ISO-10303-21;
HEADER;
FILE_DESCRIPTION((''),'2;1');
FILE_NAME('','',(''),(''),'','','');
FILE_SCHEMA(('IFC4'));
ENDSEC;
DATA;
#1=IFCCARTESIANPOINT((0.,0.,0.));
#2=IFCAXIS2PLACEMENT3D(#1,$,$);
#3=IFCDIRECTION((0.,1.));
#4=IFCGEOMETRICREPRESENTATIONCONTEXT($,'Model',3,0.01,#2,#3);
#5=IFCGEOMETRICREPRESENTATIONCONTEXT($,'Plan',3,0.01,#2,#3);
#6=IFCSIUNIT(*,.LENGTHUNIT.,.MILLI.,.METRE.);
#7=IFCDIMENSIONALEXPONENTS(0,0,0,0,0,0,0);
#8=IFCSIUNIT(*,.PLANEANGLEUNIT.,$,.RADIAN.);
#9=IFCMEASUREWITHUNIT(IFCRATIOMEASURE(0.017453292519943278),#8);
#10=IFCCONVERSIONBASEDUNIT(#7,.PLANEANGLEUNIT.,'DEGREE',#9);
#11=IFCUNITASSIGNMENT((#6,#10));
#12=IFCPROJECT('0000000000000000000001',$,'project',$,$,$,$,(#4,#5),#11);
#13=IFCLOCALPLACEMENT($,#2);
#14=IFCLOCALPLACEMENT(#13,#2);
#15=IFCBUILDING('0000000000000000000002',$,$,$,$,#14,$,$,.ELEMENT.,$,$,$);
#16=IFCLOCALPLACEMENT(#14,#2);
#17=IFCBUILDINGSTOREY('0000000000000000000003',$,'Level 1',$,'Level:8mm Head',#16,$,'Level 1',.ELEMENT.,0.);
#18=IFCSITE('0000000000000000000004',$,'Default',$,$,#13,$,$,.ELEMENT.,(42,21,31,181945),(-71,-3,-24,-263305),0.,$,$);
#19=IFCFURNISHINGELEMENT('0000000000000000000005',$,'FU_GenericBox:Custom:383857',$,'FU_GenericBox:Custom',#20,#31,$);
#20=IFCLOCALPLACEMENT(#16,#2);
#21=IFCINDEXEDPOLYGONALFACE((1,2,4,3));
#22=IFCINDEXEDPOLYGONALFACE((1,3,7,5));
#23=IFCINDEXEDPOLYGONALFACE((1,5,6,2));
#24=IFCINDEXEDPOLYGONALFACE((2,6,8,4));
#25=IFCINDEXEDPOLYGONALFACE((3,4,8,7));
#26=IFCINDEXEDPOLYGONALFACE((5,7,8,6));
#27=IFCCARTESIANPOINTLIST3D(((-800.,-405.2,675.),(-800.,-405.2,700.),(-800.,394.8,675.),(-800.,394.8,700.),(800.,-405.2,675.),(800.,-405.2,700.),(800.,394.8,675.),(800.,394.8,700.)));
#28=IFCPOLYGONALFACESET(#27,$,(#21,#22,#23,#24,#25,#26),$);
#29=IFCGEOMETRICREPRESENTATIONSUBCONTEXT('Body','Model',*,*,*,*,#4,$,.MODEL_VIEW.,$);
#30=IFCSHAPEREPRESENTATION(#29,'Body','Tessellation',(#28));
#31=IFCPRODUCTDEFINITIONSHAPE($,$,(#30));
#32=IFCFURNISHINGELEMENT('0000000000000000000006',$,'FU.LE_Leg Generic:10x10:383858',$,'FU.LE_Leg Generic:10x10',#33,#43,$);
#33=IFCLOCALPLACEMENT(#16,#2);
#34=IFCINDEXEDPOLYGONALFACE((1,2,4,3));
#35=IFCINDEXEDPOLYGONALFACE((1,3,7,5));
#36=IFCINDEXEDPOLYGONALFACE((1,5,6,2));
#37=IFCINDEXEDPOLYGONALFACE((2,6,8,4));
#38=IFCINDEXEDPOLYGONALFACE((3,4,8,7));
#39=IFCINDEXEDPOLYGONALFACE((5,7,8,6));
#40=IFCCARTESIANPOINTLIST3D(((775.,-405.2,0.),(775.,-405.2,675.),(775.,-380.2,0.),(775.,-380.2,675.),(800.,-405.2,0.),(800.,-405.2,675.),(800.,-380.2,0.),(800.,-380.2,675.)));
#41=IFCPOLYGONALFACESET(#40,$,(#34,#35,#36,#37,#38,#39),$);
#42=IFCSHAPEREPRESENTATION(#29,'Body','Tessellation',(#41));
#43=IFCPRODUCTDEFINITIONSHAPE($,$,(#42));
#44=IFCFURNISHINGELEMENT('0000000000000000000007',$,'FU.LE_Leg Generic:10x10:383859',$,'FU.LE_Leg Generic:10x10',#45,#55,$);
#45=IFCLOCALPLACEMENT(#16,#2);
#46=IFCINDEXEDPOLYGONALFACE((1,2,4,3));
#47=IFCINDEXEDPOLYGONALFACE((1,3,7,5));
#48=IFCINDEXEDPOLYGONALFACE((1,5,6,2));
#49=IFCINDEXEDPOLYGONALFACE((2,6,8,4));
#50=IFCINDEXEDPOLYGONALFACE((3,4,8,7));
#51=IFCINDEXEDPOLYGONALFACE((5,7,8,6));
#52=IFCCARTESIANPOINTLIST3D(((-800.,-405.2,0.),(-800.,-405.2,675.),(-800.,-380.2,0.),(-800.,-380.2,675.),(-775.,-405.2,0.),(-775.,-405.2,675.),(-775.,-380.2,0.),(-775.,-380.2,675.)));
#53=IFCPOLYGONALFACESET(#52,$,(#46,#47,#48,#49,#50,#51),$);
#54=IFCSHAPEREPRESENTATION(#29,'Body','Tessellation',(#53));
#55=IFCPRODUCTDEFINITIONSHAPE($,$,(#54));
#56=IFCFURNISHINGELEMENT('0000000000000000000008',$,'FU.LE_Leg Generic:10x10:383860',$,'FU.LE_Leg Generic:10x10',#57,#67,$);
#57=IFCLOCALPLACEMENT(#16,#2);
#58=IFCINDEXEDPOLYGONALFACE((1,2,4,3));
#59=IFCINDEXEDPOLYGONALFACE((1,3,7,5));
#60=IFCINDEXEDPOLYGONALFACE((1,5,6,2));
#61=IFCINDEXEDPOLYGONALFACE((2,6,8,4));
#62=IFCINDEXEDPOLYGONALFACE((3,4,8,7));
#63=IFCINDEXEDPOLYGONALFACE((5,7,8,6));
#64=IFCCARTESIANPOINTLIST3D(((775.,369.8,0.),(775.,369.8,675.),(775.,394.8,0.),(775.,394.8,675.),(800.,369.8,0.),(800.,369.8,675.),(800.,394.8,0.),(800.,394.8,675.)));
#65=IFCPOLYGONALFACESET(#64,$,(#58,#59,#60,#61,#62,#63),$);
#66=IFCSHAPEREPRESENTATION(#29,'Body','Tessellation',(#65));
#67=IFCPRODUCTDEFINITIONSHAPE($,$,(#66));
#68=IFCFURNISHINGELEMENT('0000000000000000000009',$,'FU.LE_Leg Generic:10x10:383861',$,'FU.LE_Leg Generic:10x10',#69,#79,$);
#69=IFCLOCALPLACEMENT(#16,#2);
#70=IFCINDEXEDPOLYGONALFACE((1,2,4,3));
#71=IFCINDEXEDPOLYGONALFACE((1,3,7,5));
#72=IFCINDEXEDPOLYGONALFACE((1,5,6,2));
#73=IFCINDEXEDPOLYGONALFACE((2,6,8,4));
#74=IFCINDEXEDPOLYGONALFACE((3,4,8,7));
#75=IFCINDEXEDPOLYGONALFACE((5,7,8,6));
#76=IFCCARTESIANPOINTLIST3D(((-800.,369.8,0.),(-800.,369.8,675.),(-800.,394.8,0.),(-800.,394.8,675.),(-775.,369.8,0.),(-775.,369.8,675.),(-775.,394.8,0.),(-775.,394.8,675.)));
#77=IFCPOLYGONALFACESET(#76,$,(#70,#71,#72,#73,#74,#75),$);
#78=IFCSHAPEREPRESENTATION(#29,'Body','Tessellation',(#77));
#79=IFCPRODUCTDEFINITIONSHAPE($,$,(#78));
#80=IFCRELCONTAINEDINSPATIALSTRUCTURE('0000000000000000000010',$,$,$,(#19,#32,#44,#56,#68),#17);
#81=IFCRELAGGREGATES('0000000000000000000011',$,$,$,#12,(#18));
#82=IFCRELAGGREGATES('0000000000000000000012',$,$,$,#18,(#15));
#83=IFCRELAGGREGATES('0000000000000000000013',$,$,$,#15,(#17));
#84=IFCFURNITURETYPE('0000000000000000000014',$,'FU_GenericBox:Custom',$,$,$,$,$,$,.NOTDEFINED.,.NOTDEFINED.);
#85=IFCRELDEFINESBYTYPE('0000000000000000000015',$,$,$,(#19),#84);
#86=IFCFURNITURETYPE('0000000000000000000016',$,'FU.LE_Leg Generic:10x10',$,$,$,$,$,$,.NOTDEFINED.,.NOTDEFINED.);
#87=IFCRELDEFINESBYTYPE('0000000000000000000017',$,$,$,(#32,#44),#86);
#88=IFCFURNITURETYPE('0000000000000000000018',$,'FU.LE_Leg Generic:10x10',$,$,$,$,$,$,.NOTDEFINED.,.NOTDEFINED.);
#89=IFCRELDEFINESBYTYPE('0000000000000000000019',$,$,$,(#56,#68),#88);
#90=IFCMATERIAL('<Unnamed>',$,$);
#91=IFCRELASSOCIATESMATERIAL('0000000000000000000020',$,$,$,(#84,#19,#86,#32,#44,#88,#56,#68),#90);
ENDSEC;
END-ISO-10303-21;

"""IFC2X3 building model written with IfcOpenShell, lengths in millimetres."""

from ifc_helpers import new_model, entity, si_unit, converted_unit, direction, frame, origin, origin_2d_with_axis, place, context, subcontext, project, spatial, rectangle, extrude, source, transform, mapped, material, type_object, type_shapes, element, save


model = new_model("IFC2X3")

# Units and contexts
model_context = context("Model", 3, precision=0.01, world=origin(), true_north=direction((0.0, 1.0)))
plan_context = context("Plan", 3, precision=0.01, world=origin(), true_north=direction((0.0, 1.0)))
body_context = subcontext(model_context, "Body", "Model", "MODEL_VIEW")
ifc_project = project(units=[si_unit("LENGTHUNIT", "METRE", prefix="MILLI"), converted_unit("PLANEANGLEUNIT", "DEGREE", entity("IfcRatioMeasure", 0.017453292519943278), si_unit("PLANEANGLEUNIT", "RADIAN"), dimensions=[0, 0, 0, 0, 0, 0, 0])], contexts=[model_context, plan_context])

# Site, building, storey
site_placement = place(None, origin())
site = spatial("IfcSite", under=ifc_project, at=site_placement, Name="Default", CompositionType="ELEMENT", RefLatitude=(42, 21, 31, 181945), RefLongitude=(-71, -3, -24, -263305), RefElevation=0.0)
building_placement = place(site_placement, origin())
building = spatial("IfcBuilding", under=site, at=building_placement, CompositionType="ELEMENT")
storey_placement = place(building_placement, origin())
storey = spatial("IfcBuildingStorey", under=building, at=storey_placement, Name="Level 1", ObjectType="Level:8mm Head", LongName="Level 1", CompositionType="ELEMENT", Elevation=0.0)

# Furnishing elements
ifc_material = material(Name="<Unnamed>")
furniture_type_1 = type_object("IfcFurnitureType", Name="FU_GenericBox:Custom", material=ifc_material)
shared_shape_1 = source(origin(), body_context, "Body", "SweptSolid", [
    extrude(rectangle(XDim=1600.0, YDim=800.0, at=origin_2d_with_axis()), frame((0.0, -400.0, 0.0), z_axis=(0.0, 0.0, 1.0), x_axis=(-1.0, 0.0, 0.0)), (0.0, 0.0, 1.0), 25.0),
])
type_shapes(furniture_type_1, [shared_shape_1])
furnishing_placement = place(storey_placement, frame((0.0, -405.2, 675.0), z_axis=(0.0, 0.0, 1.0), x_axis=(-1.0, 0.0, 0.0)))
element("IfcFurnishingElement", 1, at=furnishing_placement, inside=storey, type_object=furniture_type_1, material=ifc_material, Name="FU_GenericBox:Custom:383857", ObjectType="FU_GenericBox:Custom", context=body_context, shape_type="MappedRepresentation", body=[
    mapped(shared_shape_1, transform((0.0, 0.0, 0.0), scale=1.0)),
])
furniture_type_2 = type_object("IfcFurnitureType", Name="FU.LE_Leg Generic:10x10", material=ifc_material)
shared_shape_2 = source(origin(), body_context, "Body", "SweptSolid", [
    extrude(rectangle(XDim=25.0, YDim=25.0, at=origin_2d_with_axis()), frame((12.5, -12.5, 0.0), z_axis=(0.0, 0.0, 1.0), x_axis=(-1.0, 0.0, 0.0)), (0.0, 0.0, 1.0), 675.0),
])
type_shapes(furniture_type_2, [shared_shape_2])
for number, where, z_axis, x_axis, name in (
    (2, (800.0, -405.2, 0.0), (0.0, 0.0, 1.0), (-1.0, 0.0, 0.0), "FU.LE_Leg Generic:10x10:383858"),
    (3, (-800.0, -405.2, 0.0), (0.0, 0.0, 1.0), (0.0, 1.0, 0.0), "FU.LE_Leg Generic:10x10:383859"),
):
    element("IfcFurnishingElement", number, at=place(storey_placement, frame(where, z_axis=z_axis, x_axis=x_axis)), inside=storey, type_object=furniture_type_2, material=ifc_material, Name=name, ObjectType="FU.LE_Leg Generic:10x10", context=body_context, shape_type="MappedRepresentation", body=[
        mapped(shared_shape_2, transform((0.0, 0.0, 0.0), scale=1.0)),
    ])
furniture_type_3 = type_object("IfcFurnitureType", Name="FU.LE_Leg Generic:10x10", material=ifc_material)
shared_shape_3 = source(origin(), body_context, "Body", "SweptSolid", [
    extrude(rectangle(XDim=25.0, YDim=25.0, at=origin_2d_with_axis()), frame((12.5, 12.5, 0.0), z_axis=(0.0, 0.0, 1.0), x_axis=(0.0, 1.0, 0.0)), (0.0, 0.0, 1.0), 675.0),
])
type_shapes(furniture_type_3, [shared_shape_3])
for number, where, z_axis, x_axis, name in (
    (4, (800.0, 394.8, 0.0), (0.0, 0.0, 1.0), (-1.0, 0.0, 0.0), "FU.LE_Leg Generic:10x10:383860"),
    (5, (-800.0, 394.8, 0.0), (0.0, 0.0, 1.0), (0.0, -1.0, 0.0), "FU.LE_Leg Generic:10x10:383861"),
):
    element("IfcFurnishingElement", number, at=place(storey_placement, frame(where, z_axis=z_axis, x_axis=x_axis)), inside=storey, type_object=furniture_type_3, material=ifc_material, Name=name, ObjectType="FU.LE_Leg Generic:10x10", context=body_context, shape_type="MappedRepresentation", body=[
        mapped(shared_shape_3, transform((0.0, 0.0, 0.0), scale=1.0)),
    ])

save(model, "model.ifc")
